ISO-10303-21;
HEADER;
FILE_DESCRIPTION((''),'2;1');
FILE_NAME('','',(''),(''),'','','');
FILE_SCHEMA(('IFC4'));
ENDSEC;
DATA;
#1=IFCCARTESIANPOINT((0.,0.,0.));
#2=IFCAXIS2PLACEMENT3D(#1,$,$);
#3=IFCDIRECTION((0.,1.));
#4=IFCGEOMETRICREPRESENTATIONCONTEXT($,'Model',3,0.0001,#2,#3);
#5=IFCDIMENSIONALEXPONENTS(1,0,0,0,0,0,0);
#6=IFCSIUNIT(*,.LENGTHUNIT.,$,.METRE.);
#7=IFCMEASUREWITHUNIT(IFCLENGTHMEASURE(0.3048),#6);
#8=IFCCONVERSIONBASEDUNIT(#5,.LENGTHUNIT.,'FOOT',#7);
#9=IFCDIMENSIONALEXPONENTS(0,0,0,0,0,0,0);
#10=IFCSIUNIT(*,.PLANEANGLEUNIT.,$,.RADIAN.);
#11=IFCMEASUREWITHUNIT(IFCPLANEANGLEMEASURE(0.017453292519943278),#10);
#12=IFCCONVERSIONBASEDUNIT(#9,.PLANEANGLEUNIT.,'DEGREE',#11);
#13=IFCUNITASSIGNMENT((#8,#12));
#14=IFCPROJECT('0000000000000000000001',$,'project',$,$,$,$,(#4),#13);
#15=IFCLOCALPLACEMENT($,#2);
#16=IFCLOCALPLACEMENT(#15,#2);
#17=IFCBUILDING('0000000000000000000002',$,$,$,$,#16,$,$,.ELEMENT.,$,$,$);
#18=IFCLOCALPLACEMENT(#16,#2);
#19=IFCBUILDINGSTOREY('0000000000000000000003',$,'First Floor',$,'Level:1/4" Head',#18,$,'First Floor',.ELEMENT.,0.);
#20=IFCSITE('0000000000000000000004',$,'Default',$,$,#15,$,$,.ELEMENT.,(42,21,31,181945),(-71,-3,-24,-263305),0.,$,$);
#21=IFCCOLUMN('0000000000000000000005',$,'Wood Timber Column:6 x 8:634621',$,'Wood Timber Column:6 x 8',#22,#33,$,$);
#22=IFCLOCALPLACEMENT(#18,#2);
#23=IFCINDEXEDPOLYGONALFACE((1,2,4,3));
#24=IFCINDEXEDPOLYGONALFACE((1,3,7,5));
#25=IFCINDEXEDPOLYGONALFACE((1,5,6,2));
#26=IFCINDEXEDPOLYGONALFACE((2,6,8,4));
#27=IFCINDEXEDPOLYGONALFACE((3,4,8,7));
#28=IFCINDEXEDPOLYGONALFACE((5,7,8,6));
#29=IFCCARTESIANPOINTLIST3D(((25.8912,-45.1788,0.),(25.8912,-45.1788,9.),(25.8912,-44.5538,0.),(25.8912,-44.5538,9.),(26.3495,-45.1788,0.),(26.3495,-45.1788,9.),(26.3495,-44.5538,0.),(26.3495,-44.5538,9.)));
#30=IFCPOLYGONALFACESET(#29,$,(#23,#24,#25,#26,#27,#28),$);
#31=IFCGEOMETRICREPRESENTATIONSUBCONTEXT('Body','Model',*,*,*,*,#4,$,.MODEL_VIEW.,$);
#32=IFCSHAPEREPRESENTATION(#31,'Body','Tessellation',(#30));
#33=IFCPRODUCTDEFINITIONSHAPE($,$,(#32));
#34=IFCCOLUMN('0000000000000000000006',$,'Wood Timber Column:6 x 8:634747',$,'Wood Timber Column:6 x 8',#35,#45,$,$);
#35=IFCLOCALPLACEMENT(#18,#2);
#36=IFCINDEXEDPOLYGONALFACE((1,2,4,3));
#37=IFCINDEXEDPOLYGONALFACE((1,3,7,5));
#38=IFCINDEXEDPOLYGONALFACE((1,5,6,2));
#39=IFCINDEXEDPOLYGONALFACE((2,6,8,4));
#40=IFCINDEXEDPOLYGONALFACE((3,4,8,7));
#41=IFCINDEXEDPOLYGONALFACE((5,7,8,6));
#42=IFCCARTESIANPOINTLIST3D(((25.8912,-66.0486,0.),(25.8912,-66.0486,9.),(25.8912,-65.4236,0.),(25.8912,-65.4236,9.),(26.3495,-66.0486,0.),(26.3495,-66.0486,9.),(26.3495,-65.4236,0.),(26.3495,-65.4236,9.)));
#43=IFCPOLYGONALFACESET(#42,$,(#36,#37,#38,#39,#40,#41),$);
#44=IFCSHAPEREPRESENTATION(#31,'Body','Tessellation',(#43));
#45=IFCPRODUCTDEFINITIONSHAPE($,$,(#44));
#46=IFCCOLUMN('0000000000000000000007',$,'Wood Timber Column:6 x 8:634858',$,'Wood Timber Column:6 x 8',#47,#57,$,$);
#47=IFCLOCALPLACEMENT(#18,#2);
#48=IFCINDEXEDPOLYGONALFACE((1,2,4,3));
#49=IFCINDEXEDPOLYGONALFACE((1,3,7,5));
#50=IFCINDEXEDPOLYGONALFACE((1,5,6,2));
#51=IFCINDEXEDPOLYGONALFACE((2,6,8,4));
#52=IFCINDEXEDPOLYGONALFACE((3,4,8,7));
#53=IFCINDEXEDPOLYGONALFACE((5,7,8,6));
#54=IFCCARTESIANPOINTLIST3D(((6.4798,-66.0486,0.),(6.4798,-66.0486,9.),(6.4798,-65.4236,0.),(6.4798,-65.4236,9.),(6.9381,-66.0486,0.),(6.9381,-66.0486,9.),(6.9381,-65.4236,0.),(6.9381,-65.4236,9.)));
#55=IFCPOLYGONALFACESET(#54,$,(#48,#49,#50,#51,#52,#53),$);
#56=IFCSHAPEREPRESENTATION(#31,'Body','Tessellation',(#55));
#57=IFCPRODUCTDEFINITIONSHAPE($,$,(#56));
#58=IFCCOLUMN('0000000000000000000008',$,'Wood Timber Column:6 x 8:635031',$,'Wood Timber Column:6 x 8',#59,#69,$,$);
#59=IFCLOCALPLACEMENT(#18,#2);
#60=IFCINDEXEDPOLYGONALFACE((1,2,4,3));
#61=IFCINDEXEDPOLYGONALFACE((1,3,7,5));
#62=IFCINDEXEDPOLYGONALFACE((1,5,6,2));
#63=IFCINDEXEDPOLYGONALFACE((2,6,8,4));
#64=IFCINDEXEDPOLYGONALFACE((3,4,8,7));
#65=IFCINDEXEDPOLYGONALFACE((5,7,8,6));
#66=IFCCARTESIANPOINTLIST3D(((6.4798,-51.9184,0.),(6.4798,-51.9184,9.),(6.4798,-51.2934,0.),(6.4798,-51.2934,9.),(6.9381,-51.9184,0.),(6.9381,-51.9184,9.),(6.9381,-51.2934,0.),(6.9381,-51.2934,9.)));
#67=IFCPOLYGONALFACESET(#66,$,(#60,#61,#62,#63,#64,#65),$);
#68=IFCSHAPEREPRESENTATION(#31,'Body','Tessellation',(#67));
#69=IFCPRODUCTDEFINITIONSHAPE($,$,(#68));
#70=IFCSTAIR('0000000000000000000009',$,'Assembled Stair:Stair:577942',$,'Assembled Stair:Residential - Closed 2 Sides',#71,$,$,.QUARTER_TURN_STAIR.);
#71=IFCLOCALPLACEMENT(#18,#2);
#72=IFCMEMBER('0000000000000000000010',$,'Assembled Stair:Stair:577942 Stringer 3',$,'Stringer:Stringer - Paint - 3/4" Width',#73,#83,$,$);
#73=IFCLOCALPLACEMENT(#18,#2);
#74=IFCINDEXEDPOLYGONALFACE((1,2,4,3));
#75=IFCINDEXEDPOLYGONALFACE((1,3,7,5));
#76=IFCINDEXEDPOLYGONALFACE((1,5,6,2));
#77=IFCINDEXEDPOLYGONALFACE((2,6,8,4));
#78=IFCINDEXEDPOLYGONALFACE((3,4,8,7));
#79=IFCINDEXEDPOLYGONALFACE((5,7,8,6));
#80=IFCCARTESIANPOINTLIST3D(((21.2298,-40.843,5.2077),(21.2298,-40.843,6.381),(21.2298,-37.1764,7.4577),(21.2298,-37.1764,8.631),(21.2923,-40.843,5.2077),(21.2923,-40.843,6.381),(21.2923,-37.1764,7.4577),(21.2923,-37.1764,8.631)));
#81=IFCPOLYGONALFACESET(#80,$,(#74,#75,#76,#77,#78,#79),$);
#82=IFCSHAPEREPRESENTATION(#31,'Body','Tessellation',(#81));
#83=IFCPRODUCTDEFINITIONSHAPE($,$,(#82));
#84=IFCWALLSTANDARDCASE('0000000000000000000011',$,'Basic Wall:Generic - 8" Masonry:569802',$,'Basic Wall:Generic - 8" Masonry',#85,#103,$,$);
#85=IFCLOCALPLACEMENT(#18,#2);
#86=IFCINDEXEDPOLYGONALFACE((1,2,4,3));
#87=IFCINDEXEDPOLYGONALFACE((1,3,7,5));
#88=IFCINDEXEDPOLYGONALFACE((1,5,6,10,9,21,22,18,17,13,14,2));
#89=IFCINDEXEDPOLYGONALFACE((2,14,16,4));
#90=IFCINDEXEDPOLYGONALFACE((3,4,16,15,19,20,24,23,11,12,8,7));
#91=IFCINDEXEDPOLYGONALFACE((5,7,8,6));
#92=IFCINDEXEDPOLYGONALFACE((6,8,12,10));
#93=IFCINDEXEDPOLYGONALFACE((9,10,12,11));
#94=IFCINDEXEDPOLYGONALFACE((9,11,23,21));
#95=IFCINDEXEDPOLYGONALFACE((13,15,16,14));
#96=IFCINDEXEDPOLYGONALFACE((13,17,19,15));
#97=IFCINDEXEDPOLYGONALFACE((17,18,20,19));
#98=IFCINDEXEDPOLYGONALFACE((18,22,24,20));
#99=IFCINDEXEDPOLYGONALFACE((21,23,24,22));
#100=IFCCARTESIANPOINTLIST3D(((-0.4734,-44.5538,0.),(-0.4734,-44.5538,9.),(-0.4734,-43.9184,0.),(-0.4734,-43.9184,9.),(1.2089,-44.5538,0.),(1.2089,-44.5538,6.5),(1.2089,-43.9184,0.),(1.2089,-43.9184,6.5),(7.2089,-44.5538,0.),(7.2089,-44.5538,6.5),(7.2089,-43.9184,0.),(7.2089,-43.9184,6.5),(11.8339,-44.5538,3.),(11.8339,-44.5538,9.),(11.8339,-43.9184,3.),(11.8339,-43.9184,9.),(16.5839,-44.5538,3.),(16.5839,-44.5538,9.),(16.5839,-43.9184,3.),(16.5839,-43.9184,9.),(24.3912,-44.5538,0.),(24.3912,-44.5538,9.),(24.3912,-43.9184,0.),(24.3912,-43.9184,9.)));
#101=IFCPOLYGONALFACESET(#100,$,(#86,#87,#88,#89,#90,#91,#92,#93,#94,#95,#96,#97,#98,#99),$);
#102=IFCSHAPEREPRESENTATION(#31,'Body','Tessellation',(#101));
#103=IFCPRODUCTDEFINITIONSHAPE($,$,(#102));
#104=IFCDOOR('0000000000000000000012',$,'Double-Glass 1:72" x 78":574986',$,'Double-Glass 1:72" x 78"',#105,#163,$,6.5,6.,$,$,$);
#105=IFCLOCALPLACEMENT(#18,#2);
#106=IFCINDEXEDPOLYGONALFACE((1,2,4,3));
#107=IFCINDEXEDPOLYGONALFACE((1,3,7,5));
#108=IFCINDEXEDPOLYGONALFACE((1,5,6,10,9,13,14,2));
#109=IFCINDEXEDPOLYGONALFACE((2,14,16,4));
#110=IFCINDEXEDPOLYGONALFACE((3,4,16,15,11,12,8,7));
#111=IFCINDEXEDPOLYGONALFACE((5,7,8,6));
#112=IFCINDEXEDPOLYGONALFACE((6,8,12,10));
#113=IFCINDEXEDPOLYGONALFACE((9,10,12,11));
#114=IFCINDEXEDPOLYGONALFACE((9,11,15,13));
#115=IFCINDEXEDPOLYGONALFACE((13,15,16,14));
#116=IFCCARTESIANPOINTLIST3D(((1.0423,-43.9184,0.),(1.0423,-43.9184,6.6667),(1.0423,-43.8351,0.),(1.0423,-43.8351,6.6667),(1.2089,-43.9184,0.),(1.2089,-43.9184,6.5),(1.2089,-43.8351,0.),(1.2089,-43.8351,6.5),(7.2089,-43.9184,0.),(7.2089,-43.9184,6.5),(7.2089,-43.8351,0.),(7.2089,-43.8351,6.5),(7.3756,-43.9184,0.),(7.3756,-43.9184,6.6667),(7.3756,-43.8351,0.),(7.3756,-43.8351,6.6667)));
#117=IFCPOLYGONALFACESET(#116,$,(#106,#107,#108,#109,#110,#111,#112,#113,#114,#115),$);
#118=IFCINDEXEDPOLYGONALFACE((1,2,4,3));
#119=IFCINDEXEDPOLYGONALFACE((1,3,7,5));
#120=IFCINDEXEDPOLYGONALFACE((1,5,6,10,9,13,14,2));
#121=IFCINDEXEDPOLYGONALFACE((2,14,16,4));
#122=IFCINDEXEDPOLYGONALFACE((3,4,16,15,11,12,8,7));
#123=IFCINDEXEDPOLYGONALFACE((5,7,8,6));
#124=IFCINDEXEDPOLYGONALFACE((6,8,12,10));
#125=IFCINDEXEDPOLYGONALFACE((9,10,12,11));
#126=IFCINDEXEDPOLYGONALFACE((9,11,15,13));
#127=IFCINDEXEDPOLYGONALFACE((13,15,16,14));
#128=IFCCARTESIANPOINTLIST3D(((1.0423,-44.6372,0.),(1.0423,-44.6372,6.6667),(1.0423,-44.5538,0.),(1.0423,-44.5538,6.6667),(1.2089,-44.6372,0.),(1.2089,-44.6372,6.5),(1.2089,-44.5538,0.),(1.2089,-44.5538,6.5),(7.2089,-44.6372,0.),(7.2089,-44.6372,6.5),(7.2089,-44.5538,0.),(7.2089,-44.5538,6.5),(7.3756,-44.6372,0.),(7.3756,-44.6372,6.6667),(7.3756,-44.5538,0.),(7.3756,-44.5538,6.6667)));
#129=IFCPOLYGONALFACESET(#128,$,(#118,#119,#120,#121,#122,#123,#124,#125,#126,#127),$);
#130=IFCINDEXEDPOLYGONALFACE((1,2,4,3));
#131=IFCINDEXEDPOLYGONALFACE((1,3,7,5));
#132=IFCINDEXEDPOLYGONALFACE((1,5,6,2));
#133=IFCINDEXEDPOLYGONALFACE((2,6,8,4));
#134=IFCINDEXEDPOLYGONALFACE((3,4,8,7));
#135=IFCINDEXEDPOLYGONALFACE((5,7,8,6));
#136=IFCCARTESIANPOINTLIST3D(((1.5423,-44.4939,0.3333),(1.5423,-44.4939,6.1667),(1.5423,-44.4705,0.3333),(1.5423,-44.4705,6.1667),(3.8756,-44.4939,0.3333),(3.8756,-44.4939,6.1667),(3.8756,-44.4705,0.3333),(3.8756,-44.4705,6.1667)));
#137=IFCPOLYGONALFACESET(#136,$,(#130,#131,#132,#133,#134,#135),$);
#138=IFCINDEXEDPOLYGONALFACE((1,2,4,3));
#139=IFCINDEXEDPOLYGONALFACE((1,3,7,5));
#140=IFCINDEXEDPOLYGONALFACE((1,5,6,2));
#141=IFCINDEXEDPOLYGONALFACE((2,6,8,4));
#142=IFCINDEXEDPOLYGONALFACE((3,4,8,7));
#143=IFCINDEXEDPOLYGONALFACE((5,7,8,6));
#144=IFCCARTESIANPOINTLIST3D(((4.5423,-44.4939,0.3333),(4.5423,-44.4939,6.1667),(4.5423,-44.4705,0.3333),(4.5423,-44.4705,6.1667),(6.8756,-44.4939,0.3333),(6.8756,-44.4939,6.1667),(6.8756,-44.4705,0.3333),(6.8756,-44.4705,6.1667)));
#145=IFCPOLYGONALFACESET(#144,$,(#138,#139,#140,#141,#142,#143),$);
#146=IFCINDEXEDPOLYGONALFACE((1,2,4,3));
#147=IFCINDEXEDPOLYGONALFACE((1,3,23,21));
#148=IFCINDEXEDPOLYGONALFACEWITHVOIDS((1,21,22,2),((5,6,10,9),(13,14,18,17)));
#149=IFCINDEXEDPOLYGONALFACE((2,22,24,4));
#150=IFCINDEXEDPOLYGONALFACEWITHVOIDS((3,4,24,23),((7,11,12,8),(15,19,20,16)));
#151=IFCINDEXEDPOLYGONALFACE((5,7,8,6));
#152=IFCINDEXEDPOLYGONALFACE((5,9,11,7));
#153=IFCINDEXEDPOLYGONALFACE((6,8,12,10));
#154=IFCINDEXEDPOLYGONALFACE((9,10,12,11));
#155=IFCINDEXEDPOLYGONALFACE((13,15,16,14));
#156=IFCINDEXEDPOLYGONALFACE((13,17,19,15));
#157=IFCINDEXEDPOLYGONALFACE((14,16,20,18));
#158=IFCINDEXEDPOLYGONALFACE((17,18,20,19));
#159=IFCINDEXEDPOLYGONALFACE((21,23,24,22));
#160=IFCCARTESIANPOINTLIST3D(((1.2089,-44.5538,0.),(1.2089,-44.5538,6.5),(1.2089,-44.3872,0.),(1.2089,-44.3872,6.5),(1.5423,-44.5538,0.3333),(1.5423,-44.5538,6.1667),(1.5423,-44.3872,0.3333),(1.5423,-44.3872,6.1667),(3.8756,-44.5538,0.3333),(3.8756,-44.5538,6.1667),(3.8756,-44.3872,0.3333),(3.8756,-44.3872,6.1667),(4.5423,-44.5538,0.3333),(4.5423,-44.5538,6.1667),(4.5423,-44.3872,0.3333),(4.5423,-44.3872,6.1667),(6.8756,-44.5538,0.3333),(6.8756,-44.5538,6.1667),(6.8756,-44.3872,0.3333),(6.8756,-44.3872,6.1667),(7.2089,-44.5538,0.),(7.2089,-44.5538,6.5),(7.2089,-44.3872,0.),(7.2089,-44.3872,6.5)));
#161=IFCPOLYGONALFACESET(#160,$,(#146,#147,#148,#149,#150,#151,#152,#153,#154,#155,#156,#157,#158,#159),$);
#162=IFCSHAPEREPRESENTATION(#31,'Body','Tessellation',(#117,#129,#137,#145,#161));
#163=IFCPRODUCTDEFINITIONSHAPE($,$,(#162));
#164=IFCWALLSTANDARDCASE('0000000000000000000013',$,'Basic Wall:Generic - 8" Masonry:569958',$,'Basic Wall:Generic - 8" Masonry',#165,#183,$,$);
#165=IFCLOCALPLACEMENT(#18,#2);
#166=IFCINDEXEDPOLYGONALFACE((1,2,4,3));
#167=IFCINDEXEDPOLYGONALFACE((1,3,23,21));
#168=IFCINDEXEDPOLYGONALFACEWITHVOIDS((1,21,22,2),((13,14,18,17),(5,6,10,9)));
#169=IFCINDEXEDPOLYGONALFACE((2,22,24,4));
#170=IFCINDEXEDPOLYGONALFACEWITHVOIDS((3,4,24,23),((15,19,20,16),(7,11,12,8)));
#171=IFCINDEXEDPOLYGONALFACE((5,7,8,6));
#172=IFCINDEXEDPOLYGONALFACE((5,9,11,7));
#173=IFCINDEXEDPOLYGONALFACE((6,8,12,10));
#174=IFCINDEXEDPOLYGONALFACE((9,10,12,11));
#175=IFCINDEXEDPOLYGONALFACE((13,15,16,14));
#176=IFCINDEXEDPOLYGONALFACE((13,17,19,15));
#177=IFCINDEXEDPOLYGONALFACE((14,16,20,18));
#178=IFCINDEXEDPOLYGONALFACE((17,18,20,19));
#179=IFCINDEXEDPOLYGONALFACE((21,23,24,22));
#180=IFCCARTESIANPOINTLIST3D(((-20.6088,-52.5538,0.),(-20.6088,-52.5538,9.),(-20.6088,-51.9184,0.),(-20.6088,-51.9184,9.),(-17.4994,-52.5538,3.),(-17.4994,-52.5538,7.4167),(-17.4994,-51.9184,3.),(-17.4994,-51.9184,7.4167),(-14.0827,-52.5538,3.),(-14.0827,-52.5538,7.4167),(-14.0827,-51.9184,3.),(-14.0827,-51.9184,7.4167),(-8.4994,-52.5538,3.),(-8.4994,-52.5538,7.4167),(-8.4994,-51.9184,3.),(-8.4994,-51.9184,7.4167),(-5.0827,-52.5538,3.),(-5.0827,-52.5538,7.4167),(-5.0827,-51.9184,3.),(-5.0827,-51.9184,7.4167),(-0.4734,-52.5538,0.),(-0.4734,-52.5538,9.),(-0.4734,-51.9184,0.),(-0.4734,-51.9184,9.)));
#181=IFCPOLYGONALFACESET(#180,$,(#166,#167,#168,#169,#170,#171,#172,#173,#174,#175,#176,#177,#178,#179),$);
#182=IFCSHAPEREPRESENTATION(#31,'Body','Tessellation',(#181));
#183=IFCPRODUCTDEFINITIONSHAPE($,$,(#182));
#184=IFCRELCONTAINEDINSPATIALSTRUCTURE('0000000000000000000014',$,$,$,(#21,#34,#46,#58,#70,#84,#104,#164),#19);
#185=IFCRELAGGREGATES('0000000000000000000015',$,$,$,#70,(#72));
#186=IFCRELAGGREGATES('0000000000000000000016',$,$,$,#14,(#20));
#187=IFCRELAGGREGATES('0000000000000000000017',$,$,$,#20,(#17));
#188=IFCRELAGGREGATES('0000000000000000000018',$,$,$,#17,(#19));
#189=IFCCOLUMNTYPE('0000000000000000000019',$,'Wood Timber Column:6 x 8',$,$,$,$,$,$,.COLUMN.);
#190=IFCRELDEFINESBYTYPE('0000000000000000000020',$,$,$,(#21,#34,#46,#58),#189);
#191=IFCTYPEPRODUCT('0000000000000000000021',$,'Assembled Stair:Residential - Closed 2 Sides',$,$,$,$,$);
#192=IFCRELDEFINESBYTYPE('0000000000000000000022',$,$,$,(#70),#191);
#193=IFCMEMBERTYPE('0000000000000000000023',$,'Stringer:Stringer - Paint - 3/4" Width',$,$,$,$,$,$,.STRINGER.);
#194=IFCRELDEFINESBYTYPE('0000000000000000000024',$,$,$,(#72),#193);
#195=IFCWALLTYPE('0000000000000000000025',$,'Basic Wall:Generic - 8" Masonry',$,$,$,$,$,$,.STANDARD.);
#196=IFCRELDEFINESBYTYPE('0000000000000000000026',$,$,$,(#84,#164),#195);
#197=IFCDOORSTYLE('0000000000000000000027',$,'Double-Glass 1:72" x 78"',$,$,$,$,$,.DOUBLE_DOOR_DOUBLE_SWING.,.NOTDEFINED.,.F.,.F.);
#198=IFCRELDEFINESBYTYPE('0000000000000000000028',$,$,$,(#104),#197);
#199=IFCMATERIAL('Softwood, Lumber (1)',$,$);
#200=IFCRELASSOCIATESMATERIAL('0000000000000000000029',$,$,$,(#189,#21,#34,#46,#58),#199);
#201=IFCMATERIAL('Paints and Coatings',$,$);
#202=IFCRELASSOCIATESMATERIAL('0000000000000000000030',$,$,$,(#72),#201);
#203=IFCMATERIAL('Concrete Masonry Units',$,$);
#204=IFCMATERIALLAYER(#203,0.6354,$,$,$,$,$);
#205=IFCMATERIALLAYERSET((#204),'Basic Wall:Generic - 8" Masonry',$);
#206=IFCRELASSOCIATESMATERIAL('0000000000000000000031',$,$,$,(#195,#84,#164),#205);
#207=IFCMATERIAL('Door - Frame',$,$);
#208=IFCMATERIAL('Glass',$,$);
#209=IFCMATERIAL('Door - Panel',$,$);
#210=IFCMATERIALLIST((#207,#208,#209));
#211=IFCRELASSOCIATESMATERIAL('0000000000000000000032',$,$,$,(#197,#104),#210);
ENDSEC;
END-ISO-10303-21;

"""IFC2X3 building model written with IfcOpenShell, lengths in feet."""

from ifc_helpers import new_model, entity, si_unit, converted_unit, direction, frame, frame_2d, origin, origin_2d_with_axis, place, context, subcontext, project, spatial, polyline, rectangle, outline, extrude, source, transform, mapped, material, material_list, layer, layer_set, layer_usage, type_object, type_shapes, element, fill, aggregate, save


model = new_model("IFC2X3")

# Units and contexts
model_context = context("Model", 3, precision=0.0001, world=origin(), true_north=direction((0.0, 1.0)))
body_context = subcontext(model_context, "Body", "Model", "MODEL_VIEW")
ifc_project = project(units=[converted_unit("LENGTHUNIT", "FOOT", entity("IfcLengthMeasure", 0.3048), si_unit("LENGTHUNIT", "METRE"), dimensions=[1, 0, 0, 0, 0, 0, 0]), converted_unit("PLANEANGLEUNIT", "DEGREE", entity("IfcPlaneAngleMeasure", 0.017453292519943278), si_unit("PLANEANGLEUNIT", "RADIAN"), dimensions=[0, 0, 0, 0, 0, 0, 0])], contexts=[model_context])

# Site, building, storey
site_placement = place(None, origin())
site = spatial("IfcSite", under=ifc_project, at=site_placement, Name="Default", CompositionType="ELEMENT", RefLatitude=(42, 21, 31, 181945), RefLongitude=(-71, -3, -24, -263305), RefElevation=0.0)
building_placement = place(site_placement, origin())
building = spatial("IfcBuilding", under=site, at=building_placement, CompositionType="ELEMENT")
storey_placement = place(building_placement, origin())
storey = spatial("IfcBuildingStorey", under=building, at=storey_placement, Name="First Floor", ObjectType="Level:1/4\" Head", LongName="First Floor", CompositionType="ELEMENT", Elevation=0.0)

# Columns
ifc_material_1 = material(Name="Softwood, Lumber (1)")
column_type = type_object("IfcColumnType", Name="Wood Timber Column:6 x 8", PredefinedType="COLUMN", material=ifc_material_1)
shared_shape_1 = source(origin(), body_context, "Body", "SweptSolid", [
    extrude(rectangle(XDim=0.625, YDim=0.4583, at=origin_2d_with_axis()), frame((0.0, 0.0, 0.0), z_axis=(0.0, 0.0, 1.0), x_axis=(0.0, 1.0, 0.0)), (0.0, 0.0, 1.0), 9.0),
])
type_shapes(column_type, [shared_shape_1])
for number, where, name in (
    (1, (26.1204, -44.8663, 0.0), "Wood Timber Column:6 x 8:634621"),
    (2, (26.1204, -65.7361, 0.0), "Wood Timber Column:6 x 8:634747"),
    (3, (6.7089, -65.7361, 0.0), "Wood Timber Column:6 x 8:634858"),
    (4, (6.7089, -51.6059, 0.0), "Wood Timber Column:6 x 8:635031"),
):
    element("IfcColumn", number, at=place(storey_placement, frame(where)), inside=storey, type_object=column_type, material=ifc_material_1, Name=name, ObjectType="Wood Timber Column:6 x 8", context=body_context, shape_type="MappedRepresentation", body=[
        mapped(shared_shape_1, transform((0.0, 0.0, 0.0), scale=1.0)),
    ])

# Stair, member
type_product = type_object("IfcTypeProduct", Name="Assembled Stair:Residential - Closed 2 Sides")
stair_placement = place(storey_placement, origin())
stair = element("IfcStair", 5, at=stair_placement, inside=storey, type_object=type_product, Name="Assembled Stair:Stair:577942", ObjectType="Assembled Stair:Residential - Closed 2 Sides", ShapeType="QUARTER_TURN_STAIR")
ifc_material_2 = material(Name="Paints and Coatings")
member_type = type_object("IfcMemberType", Name="Stringer:Stringer - Paint - 3/4\" Width", PredefinedType="STRINGER")
member_1_placement = place(stair_placement, frame((21.2298, -40.843, 5.2077)))
member_1 = element("IfcMember", 6, at=member_1_placement, type_object=member_type, material=ifc_material_2, Name="Assembled Stair:Stair:577942 Stringer 3", ObjectType="Stringer:Stringer - Paint - 3/4\" Width", context=body_context, shape_type="SweptSolid", body=[
    extrude(outline(polyline([(-2.4578, -0.5), (1.8442, -0.5), (2.4578, 0.5), (-1.8442, 0.5), (-2.4578, -0.5)])), frame((0.0, 1.8333, 1.7116), z_axis=(1.0, 0.0, 0.0), x_axis=(0.0, 0.852323, 0.523016)), (0.0, 0.0, 1.0), 0.0625),
])

# Wall, openings, door
ifc_material_3 = material(Name="Concrete Masonry Units")
ifc_layer = layer(ifc_material_3, 0.6354)
ifc_layer_set = layer_set([ifc_layer], Name="Basic Wall:Generic - 8\" Masonry")
ifc_layer_usage_1 = layer_usage(ifc_layer_set, "AXIS2", "NEGATIVE", 0.3177)
wall_type = type_object("IfcWallType", Name="Basic Wall:Generic - 8\" Masonry", PredefinedType="STANDARD", material=ifc_layer_set)
wall_1_placement = place(storey_placement, frame((24.3912, -44.2361, 0.0), z_axis=(0.0, 0.0, 1.0), x_axis=(-1.0, 0.0, 0.0)))
wall_1 = element("IfcWallStandardCase", 7, at=wall_1_placement, inside=storey, type_object=wall_type, material=ifc_layer_usage_1, Name="Basic Wall:Generic - 8\" Masonry:569802", ObjectType="Basic Wall:Generic - 8\" Masonry", context=body_context, shape_type="SweptSolid", body=[
    extrude(rectangle(XDim=24.8646, YDim=0.6354, at=frame_2d((12.4323, 0.0), x_axis=(-1.0, 0.0))), origin(), (0.0, 0.0, 1.0), 9.0),
])
opening_1_placement = place(wall_1_placement, frame((7.8073, -0.3177, 3.0)))
element("IfcOpeningElement", 8, at=opening_1_placement, cuts=wall_1, ObjectType="Opening", context=body_context, shape_type="SweptSolid", body=[
    extrude(rectangle(XDim=6.0, YDim=4.75, at=frame_2d((3.0, 2.375), x_axis=(-1.0, 0.0))), frame((0.0, 0.0, 0.0), z_axis=(0.0, 1.0, 0.0), x_axis=(0.0, 0.0, 1.0)), (0.0, 0.0, 1.0), 0.6354),
])
opening_2_placement = place(wall_1_placement, frame((17.1823, -0.3177, 0.0)))
opening_2 = element("IfcOpeningElement", 9, at=opening_2_placement, cuts=wall_1, ObjectType="Opening", context=body_context, shape_type="SweptSolid", body=[
    extrude(rectangle(XDim=6.0, YDim=6.5, at=frame_2d((3.25, 3.0), x_axis=(0.0, 1.0))), frame((0.0, 0.0, 0.0), z_axis=(0.0, 1.0, 0.0), x_axis=(0.0, 0.0, 1.0)), (0.0, 0.0, 1.0), 0.6354),
])
ifc_material_4 = material(Name="Door - Frame")
ifc_material_5 = material(Name="Glass")
ifc_material_6 = material(Name="Door - Panel")
ifc_material_list_1 = material_list([ifc_material_4, ifc_material_5, ifc_material_6])
door_style_1 = type_object("IfcDoorStyle", Name="Double-Glass 1:72\" x 78\"", ConstructionType="NOTDEFINED", OperationType="DOUBLE_DOOR_DOUBLE_SWING", ParameterTakesPrecedence=False, Sizeable=False, material=ifc_material_list_1)
shared_shape_2 = source(origin(), body_context, "Body", "SweptSolid", [
    extrude(outline(polyline([(-3.1667, -3.2917), (-3.0, -3.2917), (-3.0, 3.2083), (3.0, 3.2083), (3.0, -3.2917), (3.1667, -3.2917), (3.1667, 3.375), (-3.1667, 3.375), (-3.1667, -3.2917)])), frame((3.0, -0.0833, 3.2917), z_axis=(0.0, 1.0, 0.0), x_axis=(-1.0, 0.0, 0.0)), (0.0, 0.0, 1.0), 0.0833),
    extrude(outline(polyline([(-3.0, -3.2083), (-3.0, 3.2917), (-3.1667, 3.2917), (-3.1667, -3.375), (3.1667, -3.375), (3.1667, 3.2917), (3.0, 3.2917), (3.0, -3.2083), (-3.0, -3.2083)])), frame((3.0, 0.6354, 3.2917), z_axis=(0.0, -1.0, 0.0), x_axis=(-1.0, 0.0, 0.0)), (0.0, 0.0, -1.0), 0.0833),
    extrude(rectangle(XDim=0.0234, YDim=2.3333, at=origin_2d_with_axis()), frame((4.5, 0.5638, 0.3333), z_axis=(0.0, 0.0, 1.0), x_axis=(0.0, 1.0, 0.0)), (0.0, 0.0, 1.0), 5.8333),
    extrude(rectangle(XDim=0.0234, YDim=2.3333, at=origin_2d_with_axis()), frame((1.5, 0.5638, 0.3333), z_axis=(0.0, 0.0, 1.0), x_axis=(0.0, 1.0, 0.0)), (0.0, 0.0, 1.0), 5.8333),
    extrude(outline(polyline([(-3.25, -3.0), (3.25, -3.0), (3.25, 3.0), (-3.25, 3.0), (-3.25, -3.0)]), holes=[polyline([(-2.9167, 0.3333), (-2.9167, 2.6667), (2.9167, 2.6667), (2.9167, 0.3333), (-2.9167, 0.3333)]), polyline([(-2.9167, -2.6667), (-2.9167, -0.3333), (2.9167, -0.3333), (2.9167, -2.6667), (-2.9167, -2.6667)])]), frame((3.0, 0.4687, 3.25), z_axis=(0.0, 1.0, 0.0), x_axis=(0.0, 0.0, -1.0)), (0.0, 0.0, 1.0), 0.1667),
])
type_shapes(door_style_1, [shared_shape_2])
door_1_placement = place(opening_2_placement, origin())
door_1 = element("IfcDoor", 10, at=door_1_placement, inside=storey, type_object=door_style_1, material=ifc_material_list_1, Name="Double-Glass 1:72\" x 78\":574986", ObjectType="Double-Glass 1:72\" x 78\"", OverallHeight=6.5, OverallWidth=6.0, context=body_context, shape_type="MappedRepresentation", body=[
    mapped(shared_shape_2, transform((0.0, 0.0, 0.0), scale=1.0)),
])
fill(opening_2, door_1)

# Wall, openings
ifc_layer_usage_2 = layer_usage(ifc_layer_set, "AXIS2", "NEGATIVE", 0.3177)
wall_2_placement = place(storey_placement, frame((-0.4734, -52.2361, 0.0), z_axis=(0.0, 0.0, 1.0), x_axis=(-1.0, 0.0, 0.0)))
wall_2 = element("IfcWallStandardCase", 11, at=wall_2_placement, inside=storey, type_object=wall_type, material=ifc_layer_usage_2, Name="Basic Wall:Generic - 8\" Masonry:569958", ObjectType="Basic Wall:Generic - 8\" Masonry", context=body_context, shape_type="SweptSolid", body=[
    extrude(rectangle(XDim=20.1354, YDim=0.6354, at=frame_2d((10.0677, 0.0), x_axis=(-1.0, 0.0))), origin(), (0.0, 0.0, 1.0), 9.0),
])
opening_3_placement = place(wall_2_placement, frame((13.6094, -0.3177, 3.0)))
element("IfcOpeningElement", 12, at=opening_3_placement, cuts=wall_2, ObjectType="Opening", context=body_context, shape_type="SweptSolid", body=[
    extrude(rectangle(XDim=4.4167, YDim=3.4167, at=frame_2d((2.2083, 1.7083), x_axis=(-1.0, 0.0))), frame((0.0, 0.0, 0.0), z_axis=(0.0, 1.0, 0.0), x_axis=(0.0, 0.0, 1.0)), (0.0, 0.0, 1.0), 0.6354),
])
opening_4_placement = place(wall_2_placement, frame((4.6094, -0.3177, 3.0)))
element("IfcOpeningElement", 13, at=opening_4_placement, cuts=wall_2, ObjectType="Opening", context=body_context, shape_type="SweptSolid", body=[
    extrude(rectangle(XDim=4.4167, YDim=3.4167, at=frame_2d((2.2083, 1.7083), x_axis=(-1.0, 0.0))), frame((0.0, 0.0, 0.0), z_axis=(0.0, 1.0, 0.0), x_axis=(0.0, 0.0, 1.0)), (0.0, 0.0, 1.0), 0.6354),
])

aggregate(stair, [member_1])

save(model, "model.ifc")
